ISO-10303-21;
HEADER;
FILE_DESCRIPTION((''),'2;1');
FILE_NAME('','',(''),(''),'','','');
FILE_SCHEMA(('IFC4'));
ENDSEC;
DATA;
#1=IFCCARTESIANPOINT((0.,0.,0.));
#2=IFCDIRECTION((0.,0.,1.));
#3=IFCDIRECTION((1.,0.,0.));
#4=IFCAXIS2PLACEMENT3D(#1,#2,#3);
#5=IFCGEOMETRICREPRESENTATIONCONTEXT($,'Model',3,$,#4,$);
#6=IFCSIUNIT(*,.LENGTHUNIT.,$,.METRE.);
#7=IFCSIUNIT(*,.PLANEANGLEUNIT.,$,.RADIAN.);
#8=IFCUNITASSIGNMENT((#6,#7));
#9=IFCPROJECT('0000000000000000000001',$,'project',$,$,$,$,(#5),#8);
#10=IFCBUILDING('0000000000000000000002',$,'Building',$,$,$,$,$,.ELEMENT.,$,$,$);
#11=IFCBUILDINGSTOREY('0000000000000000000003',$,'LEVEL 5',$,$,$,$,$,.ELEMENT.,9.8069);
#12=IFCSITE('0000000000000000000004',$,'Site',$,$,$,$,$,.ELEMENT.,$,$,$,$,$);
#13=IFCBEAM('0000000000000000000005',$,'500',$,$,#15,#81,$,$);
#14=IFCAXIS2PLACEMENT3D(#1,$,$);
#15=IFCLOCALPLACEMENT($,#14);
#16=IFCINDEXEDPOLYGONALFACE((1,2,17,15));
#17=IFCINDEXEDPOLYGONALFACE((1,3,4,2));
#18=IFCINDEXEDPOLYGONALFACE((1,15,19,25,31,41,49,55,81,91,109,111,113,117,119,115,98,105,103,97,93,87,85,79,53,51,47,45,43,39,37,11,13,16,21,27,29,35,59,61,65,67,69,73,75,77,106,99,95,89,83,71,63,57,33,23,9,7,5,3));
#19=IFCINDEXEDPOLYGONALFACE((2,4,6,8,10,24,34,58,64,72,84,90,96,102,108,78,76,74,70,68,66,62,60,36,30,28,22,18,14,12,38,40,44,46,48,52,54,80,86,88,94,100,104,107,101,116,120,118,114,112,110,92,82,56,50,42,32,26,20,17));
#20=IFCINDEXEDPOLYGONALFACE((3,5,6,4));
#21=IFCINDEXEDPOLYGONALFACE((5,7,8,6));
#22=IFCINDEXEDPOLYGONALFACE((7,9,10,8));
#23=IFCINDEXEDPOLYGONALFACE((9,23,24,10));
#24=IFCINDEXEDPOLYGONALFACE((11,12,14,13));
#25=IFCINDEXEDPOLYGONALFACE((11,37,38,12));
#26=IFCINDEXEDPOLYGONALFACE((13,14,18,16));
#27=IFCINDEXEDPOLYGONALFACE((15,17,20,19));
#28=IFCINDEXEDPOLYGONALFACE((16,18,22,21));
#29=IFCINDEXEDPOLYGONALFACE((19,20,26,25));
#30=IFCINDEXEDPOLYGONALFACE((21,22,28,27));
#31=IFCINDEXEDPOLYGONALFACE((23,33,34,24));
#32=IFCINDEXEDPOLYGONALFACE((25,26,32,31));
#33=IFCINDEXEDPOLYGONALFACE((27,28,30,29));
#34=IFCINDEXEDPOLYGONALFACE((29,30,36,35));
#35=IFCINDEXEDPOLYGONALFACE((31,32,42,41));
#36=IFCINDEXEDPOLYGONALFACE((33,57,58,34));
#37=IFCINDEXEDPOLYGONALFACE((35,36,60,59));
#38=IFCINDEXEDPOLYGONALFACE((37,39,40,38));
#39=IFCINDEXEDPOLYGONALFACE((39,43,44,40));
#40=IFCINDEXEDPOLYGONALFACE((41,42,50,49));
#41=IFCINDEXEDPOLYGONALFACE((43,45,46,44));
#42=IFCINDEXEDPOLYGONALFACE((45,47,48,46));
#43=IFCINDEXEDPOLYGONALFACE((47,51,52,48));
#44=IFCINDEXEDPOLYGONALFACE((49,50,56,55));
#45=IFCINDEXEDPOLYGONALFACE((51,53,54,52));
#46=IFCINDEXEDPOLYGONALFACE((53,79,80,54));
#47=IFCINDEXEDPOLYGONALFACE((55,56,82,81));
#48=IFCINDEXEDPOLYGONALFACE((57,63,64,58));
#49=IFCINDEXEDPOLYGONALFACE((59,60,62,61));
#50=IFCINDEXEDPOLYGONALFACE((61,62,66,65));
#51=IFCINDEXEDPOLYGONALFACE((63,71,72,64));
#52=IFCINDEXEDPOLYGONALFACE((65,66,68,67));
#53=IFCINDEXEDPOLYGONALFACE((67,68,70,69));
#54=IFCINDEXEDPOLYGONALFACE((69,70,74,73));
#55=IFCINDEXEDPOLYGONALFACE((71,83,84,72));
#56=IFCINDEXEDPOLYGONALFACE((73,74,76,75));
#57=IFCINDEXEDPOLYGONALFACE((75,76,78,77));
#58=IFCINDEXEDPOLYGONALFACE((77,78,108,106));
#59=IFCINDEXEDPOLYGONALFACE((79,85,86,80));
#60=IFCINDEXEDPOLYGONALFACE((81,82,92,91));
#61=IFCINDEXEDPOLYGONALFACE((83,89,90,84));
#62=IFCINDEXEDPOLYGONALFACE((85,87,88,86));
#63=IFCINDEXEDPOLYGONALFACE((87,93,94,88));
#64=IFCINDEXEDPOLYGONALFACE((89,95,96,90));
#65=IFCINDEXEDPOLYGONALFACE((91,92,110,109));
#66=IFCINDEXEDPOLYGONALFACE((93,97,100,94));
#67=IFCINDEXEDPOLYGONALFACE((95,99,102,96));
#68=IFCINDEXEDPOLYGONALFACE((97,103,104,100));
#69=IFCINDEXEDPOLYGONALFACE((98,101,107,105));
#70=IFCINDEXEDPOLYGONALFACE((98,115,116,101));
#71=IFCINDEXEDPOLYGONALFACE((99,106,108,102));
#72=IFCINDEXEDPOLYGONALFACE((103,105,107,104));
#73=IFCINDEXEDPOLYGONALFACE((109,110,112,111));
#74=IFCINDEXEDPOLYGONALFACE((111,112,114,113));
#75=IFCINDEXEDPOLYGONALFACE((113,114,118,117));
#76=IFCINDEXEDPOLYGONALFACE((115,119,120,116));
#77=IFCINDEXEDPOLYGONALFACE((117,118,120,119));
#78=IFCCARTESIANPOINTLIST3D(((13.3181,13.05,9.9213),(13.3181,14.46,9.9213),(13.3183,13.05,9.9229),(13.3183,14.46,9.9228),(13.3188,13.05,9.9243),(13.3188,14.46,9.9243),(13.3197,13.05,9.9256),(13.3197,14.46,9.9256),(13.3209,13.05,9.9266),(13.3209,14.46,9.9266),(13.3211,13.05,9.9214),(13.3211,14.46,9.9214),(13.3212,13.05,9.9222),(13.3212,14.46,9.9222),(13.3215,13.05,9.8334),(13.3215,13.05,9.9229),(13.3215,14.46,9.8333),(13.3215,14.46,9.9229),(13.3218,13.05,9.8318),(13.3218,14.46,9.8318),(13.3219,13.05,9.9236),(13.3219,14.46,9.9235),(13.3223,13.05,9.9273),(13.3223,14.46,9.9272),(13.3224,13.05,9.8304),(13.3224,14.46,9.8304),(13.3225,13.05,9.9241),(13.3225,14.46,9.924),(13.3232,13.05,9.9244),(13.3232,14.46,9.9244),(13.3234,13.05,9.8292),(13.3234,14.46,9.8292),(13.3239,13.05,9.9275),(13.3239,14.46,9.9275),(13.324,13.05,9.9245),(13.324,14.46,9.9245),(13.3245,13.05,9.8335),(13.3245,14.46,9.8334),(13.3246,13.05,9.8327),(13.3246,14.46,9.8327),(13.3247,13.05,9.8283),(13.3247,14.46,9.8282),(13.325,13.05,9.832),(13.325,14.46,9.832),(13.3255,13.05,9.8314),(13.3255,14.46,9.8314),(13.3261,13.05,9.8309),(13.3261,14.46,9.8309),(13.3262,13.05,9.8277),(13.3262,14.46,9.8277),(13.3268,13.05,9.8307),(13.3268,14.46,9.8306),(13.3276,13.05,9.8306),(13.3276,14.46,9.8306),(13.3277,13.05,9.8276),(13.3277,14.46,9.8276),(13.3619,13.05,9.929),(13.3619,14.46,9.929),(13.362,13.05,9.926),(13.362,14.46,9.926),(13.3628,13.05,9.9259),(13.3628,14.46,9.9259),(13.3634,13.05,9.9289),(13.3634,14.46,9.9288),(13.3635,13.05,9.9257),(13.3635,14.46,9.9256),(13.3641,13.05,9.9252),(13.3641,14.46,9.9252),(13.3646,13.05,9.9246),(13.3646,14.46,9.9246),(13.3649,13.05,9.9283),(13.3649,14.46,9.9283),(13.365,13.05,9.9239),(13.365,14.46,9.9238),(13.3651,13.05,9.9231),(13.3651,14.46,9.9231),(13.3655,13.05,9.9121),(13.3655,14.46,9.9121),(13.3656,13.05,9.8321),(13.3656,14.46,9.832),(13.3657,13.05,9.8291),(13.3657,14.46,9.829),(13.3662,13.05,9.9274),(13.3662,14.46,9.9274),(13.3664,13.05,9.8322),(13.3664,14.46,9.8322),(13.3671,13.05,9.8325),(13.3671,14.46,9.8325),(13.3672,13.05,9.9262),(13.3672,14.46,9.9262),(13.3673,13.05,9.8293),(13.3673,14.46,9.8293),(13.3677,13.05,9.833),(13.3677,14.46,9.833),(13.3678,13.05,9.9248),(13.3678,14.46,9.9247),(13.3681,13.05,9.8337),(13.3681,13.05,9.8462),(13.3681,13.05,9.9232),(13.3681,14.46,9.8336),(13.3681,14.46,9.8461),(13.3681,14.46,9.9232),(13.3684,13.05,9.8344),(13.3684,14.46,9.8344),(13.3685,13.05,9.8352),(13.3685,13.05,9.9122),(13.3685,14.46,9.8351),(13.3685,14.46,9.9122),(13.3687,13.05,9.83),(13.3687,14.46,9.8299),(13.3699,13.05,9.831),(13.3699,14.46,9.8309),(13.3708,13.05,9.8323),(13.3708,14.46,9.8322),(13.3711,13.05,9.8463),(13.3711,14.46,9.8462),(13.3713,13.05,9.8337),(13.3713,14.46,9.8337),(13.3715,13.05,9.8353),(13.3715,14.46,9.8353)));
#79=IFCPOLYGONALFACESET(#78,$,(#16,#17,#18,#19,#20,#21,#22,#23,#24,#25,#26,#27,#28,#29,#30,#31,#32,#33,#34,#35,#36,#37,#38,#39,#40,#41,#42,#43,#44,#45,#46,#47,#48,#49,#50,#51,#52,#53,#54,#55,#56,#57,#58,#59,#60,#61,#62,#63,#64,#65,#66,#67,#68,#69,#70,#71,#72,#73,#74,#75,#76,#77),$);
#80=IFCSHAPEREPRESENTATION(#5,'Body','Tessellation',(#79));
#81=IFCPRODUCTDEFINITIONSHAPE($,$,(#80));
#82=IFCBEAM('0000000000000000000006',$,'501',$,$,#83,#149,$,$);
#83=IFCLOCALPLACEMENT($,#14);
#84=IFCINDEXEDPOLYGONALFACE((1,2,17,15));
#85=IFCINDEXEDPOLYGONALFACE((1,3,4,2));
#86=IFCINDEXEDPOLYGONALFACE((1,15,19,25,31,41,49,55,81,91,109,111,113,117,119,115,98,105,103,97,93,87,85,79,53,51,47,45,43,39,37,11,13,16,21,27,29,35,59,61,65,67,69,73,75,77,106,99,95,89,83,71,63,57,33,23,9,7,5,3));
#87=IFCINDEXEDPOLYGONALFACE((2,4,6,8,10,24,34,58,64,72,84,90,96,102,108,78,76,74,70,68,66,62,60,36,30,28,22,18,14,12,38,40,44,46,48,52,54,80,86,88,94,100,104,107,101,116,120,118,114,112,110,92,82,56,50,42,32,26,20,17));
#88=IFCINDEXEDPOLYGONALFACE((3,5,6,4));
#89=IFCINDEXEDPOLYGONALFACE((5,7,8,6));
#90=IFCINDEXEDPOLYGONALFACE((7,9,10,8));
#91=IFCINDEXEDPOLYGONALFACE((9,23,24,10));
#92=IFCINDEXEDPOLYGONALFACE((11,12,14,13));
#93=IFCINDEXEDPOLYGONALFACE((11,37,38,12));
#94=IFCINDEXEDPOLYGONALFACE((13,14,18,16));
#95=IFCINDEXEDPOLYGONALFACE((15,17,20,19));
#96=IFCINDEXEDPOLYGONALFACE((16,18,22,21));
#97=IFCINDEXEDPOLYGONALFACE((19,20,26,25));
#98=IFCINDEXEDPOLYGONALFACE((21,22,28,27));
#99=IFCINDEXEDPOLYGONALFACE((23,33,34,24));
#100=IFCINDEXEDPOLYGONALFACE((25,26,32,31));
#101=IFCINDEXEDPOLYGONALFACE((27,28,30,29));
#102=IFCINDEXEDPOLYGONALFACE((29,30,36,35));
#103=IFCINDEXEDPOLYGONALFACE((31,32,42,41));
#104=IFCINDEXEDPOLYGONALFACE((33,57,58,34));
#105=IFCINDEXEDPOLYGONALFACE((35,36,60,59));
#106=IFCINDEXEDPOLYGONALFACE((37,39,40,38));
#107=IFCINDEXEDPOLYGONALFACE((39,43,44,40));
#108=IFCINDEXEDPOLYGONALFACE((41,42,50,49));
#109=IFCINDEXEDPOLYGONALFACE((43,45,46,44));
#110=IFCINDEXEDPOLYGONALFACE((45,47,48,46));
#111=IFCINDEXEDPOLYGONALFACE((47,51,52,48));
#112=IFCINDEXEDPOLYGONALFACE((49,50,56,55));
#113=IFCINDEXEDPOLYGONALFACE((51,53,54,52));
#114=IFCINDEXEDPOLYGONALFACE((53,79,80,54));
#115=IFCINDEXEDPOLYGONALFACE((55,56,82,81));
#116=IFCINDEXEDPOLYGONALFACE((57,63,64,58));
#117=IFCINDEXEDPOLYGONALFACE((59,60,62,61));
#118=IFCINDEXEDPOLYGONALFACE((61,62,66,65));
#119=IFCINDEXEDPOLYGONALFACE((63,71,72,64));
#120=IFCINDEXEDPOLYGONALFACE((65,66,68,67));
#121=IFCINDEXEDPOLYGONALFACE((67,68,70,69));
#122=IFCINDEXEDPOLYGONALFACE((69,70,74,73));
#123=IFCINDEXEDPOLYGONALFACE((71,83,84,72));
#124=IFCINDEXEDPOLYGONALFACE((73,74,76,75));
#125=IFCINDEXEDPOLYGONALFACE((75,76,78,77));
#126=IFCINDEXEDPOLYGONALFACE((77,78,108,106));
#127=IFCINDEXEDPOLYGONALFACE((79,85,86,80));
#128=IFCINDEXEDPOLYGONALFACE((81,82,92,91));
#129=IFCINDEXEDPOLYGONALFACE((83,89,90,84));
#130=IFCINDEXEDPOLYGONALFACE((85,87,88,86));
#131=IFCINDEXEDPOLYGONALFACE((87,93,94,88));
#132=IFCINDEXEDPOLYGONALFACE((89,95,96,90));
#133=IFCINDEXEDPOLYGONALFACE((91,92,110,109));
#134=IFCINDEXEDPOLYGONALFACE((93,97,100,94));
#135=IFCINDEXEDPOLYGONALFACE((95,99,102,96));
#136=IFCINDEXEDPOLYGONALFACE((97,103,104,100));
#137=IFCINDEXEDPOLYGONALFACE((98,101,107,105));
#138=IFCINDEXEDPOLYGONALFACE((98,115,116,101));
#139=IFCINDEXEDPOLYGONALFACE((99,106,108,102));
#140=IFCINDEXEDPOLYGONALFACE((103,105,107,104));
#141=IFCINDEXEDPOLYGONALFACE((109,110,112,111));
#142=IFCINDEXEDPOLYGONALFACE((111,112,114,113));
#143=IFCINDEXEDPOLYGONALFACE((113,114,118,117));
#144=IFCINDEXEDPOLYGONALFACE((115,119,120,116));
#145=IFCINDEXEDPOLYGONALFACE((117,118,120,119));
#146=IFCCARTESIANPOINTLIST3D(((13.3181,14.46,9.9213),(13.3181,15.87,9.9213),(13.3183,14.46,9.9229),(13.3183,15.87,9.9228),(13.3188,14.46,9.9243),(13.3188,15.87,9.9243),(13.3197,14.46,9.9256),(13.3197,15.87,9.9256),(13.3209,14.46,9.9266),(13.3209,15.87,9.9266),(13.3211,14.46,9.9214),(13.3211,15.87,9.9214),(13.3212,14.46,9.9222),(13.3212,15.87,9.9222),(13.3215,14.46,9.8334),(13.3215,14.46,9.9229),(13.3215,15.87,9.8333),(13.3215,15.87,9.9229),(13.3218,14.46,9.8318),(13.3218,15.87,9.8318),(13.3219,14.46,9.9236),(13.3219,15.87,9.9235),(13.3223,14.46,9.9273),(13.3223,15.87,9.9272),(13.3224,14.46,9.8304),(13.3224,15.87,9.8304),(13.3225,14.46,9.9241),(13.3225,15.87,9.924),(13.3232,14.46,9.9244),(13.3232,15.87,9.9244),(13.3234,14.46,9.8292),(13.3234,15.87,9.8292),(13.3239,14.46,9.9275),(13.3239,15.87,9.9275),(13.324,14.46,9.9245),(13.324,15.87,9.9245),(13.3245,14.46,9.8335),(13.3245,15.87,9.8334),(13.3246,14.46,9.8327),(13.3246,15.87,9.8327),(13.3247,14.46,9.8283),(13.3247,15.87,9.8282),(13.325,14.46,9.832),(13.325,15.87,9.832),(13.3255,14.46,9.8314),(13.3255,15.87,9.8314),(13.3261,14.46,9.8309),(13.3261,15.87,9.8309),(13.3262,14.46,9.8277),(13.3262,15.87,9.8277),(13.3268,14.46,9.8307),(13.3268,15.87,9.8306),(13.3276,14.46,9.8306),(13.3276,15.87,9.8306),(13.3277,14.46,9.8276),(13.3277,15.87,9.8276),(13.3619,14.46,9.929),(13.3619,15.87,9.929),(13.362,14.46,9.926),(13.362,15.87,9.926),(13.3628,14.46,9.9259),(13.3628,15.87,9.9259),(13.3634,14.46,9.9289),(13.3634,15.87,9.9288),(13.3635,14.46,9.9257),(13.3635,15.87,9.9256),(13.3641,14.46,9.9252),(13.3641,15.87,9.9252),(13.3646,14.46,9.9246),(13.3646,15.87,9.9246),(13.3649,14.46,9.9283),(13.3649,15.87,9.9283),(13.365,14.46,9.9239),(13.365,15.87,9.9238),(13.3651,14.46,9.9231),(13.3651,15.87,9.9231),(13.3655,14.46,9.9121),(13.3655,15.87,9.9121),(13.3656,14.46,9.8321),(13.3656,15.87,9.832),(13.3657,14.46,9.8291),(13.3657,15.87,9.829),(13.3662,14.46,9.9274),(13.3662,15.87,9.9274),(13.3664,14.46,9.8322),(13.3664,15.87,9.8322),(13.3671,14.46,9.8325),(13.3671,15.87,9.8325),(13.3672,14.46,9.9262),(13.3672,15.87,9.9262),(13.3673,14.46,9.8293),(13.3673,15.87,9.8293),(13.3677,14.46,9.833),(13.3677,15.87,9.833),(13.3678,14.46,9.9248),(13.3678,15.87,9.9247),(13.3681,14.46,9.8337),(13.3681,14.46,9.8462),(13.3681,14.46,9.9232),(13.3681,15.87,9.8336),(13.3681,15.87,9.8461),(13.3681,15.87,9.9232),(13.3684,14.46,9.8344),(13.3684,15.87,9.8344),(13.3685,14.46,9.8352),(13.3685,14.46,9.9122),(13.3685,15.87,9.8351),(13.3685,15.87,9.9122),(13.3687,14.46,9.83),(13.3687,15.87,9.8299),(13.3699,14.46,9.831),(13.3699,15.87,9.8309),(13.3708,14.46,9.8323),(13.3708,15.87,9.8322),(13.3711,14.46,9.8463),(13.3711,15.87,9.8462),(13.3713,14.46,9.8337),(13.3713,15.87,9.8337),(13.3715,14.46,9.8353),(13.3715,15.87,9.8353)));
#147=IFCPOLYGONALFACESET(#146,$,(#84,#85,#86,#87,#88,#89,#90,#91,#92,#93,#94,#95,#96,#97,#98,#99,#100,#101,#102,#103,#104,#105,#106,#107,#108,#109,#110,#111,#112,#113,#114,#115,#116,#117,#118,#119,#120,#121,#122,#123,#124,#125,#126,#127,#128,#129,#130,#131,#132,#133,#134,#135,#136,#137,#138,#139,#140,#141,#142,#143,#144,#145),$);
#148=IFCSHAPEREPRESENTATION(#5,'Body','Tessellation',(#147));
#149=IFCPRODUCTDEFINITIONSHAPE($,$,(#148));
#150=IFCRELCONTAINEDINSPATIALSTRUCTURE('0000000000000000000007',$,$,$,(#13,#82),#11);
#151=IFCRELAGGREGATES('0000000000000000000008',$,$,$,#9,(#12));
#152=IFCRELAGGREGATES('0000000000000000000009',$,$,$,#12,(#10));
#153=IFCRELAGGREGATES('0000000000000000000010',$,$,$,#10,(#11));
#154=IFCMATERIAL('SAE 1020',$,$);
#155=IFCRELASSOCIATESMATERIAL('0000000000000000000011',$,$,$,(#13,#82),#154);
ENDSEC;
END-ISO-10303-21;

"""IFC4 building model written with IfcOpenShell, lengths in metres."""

from ifc_helpers import new_model, si_unit, frame, origin_with_axes, origin_2d_with_axis, place, context, project, spatial, c_section, extrude, material, material_profile, profile_set, profile_usage, element, save


model = new_model("IFC4")

# Units and contexts
model_context = context("Model", 3, world=origin_with_axes())
ifc_project = project(units=[si_unit("LENGTHUNIT", "METRE"), si_unit("PLANEANGLEUNIT", "RADIAN")], contexts=[model_context])

# Site, building, storey
site = spatial("IfcSite", under=ifc_project, Name="Site", CompositionType="ELEMENT")
building = spatial("IfcBuilding", under=site, Name="Building", CompositionType="ELEMENT")
storey = spatial("IfcBuildingStorey", under=building, Name="LEVEL 5", CompositionType="ELEMENT", Elevation=9.8069)

# Beams
ifc_material = material(Name="SAE 1020")
ifc_material_profile_1 = material_profile(ifc_material, c_section(Depth=0.1, Width=0.05, WallThickness=0.003, Girth=0.017, InternalFilletRadius=0.003, at=origin_2d_with_axis()))
ifc_profile_set_1 = profile_set([ifc_material_profile_1])
ifc_profile_usage_1 = profile_usage(ifc_profile_set_1, cardinal=10)
beam_1_placement = place(None, frame((13.3448, 13.05, 9.8783), z_axis=(0.0, 1.0, -0.00003), x_axis=(0.999256, 0.000001, 0.038562)))
element("IfcBeam", 1, at=beam_1_placement, inside=storey, material=ifc_profile_usage_1, Name="500", context=model_context, shape_type="SweptSolid", body=[
    extrude(c_section(Depth=0.1, Width=0.05, WallThickness=0.003, Girth=0.017, InternalFilletRadius=0.003, at=origin_2d_with_axis()), origin_with_axes(), (0.0, 0.0, 1.0), 1.41),
])
ifc_material_profile_2 = material_profile(ifc_material, c_section(Depth=0.1, Width=0.05, WallThickness=0.003, Girth=0.017, InternalFilletRadius=0.003, at=origin_2d_with_axis()))
ifc_profile_set_2 = profile_set([ifc_material_profile_2])
ifc_profile_usage_2 = profile_usage(ifc_profile_set_2, cardinal=10)
beam_2_placement = place(None, frame((13.3448, 14.46, 9.8783), z_axis=(0.0, 1.0, -0.00003), x_axis=(0.999256, 0.000001, 0.038562)))
element("IfcBeam", 2, at=beam_2_placement, inside=storey, material=ifc_profile_usage_2, Name="501", context=model_context, shape_type="SweptSolid", body=[
    extrude(c_section(Depth=0.1, Width=0.05, WallThickness=0.003, Girth=0.017, InternalFilletRadius=0.003, at=origin_2d_with_axis()), origin_with_axes(), (0.0, 0.0, 1.0), 1.41),
])

save(model, "model.ifc")
